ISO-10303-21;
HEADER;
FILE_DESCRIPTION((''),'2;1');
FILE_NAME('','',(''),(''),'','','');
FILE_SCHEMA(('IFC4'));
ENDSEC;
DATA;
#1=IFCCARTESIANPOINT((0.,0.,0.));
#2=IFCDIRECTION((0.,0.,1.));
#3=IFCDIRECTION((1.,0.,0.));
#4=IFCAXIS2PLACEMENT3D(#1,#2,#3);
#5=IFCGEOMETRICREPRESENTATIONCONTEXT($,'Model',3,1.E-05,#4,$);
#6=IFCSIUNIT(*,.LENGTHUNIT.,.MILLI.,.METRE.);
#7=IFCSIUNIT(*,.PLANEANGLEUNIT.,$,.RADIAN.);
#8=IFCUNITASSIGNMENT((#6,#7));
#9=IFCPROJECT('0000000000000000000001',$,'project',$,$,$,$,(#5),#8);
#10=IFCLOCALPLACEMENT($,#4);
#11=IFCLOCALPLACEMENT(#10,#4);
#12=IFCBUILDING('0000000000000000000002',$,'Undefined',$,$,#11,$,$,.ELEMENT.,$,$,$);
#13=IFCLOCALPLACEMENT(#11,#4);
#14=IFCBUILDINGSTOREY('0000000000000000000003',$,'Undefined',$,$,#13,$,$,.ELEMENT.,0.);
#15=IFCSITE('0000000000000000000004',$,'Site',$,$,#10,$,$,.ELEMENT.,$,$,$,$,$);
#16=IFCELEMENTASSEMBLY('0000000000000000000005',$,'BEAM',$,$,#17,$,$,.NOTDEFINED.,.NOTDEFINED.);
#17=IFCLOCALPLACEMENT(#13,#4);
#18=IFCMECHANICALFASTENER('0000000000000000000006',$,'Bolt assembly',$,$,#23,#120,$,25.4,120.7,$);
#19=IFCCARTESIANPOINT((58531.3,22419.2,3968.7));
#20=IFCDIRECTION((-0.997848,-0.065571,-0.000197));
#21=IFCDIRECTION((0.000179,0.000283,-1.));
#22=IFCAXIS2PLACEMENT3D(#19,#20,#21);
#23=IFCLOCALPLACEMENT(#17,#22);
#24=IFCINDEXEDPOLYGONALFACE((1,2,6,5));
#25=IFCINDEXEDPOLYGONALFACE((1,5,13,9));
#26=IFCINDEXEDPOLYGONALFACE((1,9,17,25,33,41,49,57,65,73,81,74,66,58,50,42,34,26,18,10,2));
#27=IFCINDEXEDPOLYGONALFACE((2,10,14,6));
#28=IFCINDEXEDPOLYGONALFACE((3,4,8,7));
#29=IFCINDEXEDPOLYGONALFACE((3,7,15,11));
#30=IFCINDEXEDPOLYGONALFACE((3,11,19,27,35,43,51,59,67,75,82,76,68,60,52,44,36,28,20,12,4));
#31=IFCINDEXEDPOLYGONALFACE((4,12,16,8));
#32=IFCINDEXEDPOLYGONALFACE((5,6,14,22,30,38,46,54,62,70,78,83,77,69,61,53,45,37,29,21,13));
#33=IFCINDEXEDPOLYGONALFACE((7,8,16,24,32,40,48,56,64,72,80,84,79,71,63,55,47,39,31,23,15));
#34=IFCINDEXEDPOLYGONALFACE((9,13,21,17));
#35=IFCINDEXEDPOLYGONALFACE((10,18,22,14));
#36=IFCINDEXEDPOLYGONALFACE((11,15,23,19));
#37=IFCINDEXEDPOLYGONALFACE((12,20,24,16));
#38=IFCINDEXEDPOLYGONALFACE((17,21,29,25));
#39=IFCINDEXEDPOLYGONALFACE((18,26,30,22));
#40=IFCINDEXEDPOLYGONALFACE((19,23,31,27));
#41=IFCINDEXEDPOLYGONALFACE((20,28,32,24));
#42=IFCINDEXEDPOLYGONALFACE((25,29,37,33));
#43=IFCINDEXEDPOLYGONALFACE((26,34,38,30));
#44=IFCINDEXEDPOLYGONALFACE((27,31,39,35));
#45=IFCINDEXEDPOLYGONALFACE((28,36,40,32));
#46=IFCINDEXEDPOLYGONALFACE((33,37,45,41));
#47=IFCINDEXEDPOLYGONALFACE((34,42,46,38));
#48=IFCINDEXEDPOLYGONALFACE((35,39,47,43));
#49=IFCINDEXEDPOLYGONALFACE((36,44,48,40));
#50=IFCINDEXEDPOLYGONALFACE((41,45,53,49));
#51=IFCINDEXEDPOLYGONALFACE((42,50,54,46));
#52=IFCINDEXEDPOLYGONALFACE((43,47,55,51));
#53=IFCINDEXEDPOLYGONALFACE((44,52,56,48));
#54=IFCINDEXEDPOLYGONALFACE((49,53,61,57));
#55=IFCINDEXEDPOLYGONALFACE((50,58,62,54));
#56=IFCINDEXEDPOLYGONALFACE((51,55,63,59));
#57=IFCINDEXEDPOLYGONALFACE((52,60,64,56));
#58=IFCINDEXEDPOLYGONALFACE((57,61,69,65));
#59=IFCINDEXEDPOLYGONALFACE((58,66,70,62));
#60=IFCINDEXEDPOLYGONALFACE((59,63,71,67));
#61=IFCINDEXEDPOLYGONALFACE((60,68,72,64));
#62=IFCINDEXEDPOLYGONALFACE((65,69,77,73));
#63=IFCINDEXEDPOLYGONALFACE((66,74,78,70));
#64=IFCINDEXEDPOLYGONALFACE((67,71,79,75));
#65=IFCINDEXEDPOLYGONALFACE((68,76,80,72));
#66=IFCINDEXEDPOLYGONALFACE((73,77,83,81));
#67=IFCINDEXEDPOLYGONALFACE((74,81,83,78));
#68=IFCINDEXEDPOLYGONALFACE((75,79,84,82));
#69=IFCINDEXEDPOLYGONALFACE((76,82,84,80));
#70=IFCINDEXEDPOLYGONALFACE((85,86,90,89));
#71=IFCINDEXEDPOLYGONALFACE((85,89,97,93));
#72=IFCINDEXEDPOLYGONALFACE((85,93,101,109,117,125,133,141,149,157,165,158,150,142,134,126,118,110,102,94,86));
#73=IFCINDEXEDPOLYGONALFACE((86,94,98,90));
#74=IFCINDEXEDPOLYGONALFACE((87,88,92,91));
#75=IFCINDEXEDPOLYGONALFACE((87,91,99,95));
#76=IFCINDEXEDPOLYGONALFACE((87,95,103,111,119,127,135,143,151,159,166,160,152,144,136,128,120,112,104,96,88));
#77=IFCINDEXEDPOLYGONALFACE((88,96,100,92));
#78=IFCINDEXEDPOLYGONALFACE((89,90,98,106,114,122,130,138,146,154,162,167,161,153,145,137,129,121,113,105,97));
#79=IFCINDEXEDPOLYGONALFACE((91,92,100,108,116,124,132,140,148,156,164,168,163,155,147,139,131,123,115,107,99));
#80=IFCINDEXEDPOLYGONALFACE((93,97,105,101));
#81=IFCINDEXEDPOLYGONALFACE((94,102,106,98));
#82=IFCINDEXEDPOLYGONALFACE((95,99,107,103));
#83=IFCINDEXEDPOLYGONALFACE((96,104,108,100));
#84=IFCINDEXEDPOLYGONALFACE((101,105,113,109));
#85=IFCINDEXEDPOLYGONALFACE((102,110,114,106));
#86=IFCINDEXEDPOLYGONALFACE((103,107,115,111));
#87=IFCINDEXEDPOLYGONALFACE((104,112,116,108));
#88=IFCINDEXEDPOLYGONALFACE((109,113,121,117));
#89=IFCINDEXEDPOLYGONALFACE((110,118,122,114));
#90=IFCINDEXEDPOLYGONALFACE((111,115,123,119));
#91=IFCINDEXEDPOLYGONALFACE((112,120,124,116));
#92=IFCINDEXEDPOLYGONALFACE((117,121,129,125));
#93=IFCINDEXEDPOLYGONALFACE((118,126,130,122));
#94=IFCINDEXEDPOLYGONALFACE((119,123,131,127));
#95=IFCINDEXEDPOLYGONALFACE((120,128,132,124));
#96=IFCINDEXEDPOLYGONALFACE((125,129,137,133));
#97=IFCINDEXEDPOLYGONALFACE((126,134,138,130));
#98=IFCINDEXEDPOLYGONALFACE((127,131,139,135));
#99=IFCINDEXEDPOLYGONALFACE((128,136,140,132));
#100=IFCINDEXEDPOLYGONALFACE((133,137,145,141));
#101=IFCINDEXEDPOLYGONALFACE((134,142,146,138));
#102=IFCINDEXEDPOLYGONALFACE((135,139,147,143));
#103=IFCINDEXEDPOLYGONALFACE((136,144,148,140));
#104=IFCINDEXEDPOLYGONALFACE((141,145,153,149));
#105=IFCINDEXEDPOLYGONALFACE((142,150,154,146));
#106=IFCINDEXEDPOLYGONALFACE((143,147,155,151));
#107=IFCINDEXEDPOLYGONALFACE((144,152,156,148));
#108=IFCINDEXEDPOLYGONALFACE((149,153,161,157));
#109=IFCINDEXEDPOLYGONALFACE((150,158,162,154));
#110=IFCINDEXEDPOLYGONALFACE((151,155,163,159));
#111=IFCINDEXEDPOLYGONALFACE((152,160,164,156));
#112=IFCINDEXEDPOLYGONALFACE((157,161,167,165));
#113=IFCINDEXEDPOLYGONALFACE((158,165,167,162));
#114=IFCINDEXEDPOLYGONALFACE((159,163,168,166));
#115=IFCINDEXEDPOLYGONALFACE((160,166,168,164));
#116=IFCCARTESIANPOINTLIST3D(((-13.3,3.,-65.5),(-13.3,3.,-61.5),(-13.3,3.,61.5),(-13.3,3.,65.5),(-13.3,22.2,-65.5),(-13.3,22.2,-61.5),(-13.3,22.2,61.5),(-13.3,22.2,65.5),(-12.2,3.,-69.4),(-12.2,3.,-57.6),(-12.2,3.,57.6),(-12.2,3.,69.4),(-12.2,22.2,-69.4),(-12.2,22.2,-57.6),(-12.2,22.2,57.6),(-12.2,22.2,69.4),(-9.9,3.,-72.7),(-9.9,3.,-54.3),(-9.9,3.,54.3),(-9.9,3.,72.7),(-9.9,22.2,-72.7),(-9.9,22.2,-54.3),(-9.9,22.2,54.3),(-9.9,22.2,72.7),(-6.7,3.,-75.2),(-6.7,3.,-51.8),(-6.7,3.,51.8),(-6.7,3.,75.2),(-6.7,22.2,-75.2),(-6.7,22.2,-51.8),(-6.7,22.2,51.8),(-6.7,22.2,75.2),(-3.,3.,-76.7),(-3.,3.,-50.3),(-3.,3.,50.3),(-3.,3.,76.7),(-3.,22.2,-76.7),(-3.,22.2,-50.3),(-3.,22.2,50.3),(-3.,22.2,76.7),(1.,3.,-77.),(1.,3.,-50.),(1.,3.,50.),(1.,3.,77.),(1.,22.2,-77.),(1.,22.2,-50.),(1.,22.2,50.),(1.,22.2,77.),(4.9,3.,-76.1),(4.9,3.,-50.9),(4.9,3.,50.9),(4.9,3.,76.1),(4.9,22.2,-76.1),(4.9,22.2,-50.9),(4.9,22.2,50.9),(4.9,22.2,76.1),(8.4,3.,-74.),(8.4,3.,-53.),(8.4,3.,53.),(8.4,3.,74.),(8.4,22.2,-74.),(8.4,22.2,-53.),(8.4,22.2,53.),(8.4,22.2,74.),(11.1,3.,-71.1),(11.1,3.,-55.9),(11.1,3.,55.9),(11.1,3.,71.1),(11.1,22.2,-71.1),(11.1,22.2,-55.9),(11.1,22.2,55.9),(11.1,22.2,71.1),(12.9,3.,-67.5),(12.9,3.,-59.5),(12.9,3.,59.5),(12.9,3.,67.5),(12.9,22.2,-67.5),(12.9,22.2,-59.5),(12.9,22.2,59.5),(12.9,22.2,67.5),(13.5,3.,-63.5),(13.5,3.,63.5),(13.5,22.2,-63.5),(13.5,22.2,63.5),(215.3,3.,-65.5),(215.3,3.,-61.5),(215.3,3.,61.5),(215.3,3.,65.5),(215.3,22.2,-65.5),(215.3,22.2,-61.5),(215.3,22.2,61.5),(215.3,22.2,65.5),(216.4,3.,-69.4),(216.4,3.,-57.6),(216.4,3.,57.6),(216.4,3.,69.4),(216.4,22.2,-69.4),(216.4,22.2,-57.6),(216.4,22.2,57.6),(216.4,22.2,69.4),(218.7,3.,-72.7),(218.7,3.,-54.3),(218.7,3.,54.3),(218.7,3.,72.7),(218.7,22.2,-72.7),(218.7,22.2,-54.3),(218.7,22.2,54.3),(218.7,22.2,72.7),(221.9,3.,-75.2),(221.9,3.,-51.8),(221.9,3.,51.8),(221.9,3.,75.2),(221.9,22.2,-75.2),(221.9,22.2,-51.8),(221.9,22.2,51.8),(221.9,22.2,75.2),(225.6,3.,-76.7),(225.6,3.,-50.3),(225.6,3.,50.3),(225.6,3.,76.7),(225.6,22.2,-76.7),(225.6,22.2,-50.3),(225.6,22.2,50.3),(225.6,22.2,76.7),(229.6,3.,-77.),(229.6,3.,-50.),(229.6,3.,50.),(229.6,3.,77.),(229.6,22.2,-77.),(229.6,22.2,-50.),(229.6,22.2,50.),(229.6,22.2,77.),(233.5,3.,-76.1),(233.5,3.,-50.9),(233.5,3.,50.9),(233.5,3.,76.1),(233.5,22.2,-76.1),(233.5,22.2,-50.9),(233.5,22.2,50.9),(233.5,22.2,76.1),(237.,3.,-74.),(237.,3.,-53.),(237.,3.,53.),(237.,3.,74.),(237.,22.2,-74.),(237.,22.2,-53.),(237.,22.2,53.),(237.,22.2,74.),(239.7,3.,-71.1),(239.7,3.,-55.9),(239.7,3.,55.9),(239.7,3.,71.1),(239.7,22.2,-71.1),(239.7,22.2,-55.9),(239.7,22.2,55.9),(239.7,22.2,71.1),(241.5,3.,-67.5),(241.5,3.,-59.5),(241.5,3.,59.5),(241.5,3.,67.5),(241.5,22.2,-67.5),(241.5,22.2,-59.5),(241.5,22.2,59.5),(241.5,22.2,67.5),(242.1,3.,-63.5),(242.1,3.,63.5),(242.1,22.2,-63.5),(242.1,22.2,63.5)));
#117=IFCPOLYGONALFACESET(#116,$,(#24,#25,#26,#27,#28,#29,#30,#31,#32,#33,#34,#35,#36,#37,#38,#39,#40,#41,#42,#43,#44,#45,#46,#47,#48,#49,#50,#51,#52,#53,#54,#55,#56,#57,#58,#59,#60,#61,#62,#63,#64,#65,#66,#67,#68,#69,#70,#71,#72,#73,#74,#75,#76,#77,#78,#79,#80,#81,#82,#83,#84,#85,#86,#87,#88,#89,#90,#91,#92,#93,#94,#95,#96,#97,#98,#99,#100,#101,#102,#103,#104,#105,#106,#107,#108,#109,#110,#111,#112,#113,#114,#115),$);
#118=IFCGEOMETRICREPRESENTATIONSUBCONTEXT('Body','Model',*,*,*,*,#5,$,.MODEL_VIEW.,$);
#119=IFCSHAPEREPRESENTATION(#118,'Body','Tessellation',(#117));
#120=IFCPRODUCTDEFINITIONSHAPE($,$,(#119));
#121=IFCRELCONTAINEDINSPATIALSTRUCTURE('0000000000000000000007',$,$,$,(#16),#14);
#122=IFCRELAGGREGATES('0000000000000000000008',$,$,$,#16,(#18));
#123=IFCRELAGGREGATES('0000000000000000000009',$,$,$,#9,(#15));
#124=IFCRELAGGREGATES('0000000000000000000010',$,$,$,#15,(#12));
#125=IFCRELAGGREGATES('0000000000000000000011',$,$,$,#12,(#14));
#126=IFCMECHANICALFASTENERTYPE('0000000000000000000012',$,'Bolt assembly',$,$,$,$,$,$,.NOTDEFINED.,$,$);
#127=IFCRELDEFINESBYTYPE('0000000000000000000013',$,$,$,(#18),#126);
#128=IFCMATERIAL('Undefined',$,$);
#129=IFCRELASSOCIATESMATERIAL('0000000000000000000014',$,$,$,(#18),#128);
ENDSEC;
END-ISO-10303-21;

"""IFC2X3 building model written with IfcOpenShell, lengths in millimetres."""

from ifc_helpers import new_model, si_unit, frame, origin_with_axes, origin_2d_with_axis, place, context, subcontext, project, spatial, circle, extrude, source, transform, mapped, material, type_object, element, aggregate, save


model = new_model("IFC2X3")

# Units and contexts
model_context = context("Model", 3, precision=1e-05, world=origin_with_axes())
body_context = subcontext(model_context, "Body", "Model", "MODEL_VIEW")
ifc_project = project(units=[si_unit("LENGTHUNIT", "METRE", prefix="MILLI"), si_unit("PLANEANGLEUNIT", "RADIAN")], contexts=[model_context])

# Site, building, storey
site_placement = place(None, origin_with_axes())
site = spatial("IfcSite", under=ifc_project, at=site_placement, Name="Site", CompositionType="ELEMENT")
building_placement = place(site_placement, origin_with_axes())
building = spatial("IfcBuilding", under=site, at=building_placement, Name="Undefined", CompositionType="ELEMENT")
storey_placement = place(building_placement, origin_with_axes())
storey = spatial("IfcBuildingStorey", under=building, at=storey_placement, Name="Undefined", CompositionType="ELEMENT", Elevation=0.0)

# Element assembly
assembly_1_placement = place(storey_placement, origin_with_axes())
assembly_1 = element("IfcElementAssembly", 1, at=assembly_1_placement, inside=storey, Name="BEAM", AssemblyPlace="NOTDEFINED", PredefinedType="NOTDEFINED")

# Mechanical fastener
ifc_material_1 = material(Name="Undefined")
mechanical_fastener_type = type_object("IfcMechanicalFastenerType", Name="Bolt assembly")
shared_shape_1 = source(origin_with_axes(), body_context, "Body", "SweptSolid", [
    extrude(circle(Radius=13.5, at=origin_2d_with_axis()), frame((0.0, 3.0, 0.0), z_axis=(0.0, 1.0, 0.0), x_axis=(1.0, 0.0, 0.0)), (0.0, 0.0, 1.0), 19.1),
])
mechanical_fastener_1_placement = place(assembly_1_placement, frame((58531.3, 22419.2, 3968.7), z_axis=(-0.997848, -0.065571, -0.000197), x_axis=(0.000179, 0.000283, -1.0)))
mechanical_fastener_1 = element("IfcMechanicalFastener", 2, at=mechanical_fastener_1_placement, type_object=mechanical_fastener_type, material=ifc_material_1, Name="Bolt assembly", NominalDiameter=25.4, NominalLength=120.7, context=body_context, shape_type="MappedRepresentation", body=[
    mapped(shared_shape_1, transform((0.0, 0.0, -63.5))),
    mapped(shared_shape_1, transform((228.6, 0.0, -63.5))),
    mapped(shared_shape_1, transform((0.0, 0.0, 63.5))),
    mapped(shared_shape_1, transform((228.6, 0.0, 63.5))),
])
aggregate(assembly_1, [mechanical_fastener_1])

save(model, "model.ifc")
